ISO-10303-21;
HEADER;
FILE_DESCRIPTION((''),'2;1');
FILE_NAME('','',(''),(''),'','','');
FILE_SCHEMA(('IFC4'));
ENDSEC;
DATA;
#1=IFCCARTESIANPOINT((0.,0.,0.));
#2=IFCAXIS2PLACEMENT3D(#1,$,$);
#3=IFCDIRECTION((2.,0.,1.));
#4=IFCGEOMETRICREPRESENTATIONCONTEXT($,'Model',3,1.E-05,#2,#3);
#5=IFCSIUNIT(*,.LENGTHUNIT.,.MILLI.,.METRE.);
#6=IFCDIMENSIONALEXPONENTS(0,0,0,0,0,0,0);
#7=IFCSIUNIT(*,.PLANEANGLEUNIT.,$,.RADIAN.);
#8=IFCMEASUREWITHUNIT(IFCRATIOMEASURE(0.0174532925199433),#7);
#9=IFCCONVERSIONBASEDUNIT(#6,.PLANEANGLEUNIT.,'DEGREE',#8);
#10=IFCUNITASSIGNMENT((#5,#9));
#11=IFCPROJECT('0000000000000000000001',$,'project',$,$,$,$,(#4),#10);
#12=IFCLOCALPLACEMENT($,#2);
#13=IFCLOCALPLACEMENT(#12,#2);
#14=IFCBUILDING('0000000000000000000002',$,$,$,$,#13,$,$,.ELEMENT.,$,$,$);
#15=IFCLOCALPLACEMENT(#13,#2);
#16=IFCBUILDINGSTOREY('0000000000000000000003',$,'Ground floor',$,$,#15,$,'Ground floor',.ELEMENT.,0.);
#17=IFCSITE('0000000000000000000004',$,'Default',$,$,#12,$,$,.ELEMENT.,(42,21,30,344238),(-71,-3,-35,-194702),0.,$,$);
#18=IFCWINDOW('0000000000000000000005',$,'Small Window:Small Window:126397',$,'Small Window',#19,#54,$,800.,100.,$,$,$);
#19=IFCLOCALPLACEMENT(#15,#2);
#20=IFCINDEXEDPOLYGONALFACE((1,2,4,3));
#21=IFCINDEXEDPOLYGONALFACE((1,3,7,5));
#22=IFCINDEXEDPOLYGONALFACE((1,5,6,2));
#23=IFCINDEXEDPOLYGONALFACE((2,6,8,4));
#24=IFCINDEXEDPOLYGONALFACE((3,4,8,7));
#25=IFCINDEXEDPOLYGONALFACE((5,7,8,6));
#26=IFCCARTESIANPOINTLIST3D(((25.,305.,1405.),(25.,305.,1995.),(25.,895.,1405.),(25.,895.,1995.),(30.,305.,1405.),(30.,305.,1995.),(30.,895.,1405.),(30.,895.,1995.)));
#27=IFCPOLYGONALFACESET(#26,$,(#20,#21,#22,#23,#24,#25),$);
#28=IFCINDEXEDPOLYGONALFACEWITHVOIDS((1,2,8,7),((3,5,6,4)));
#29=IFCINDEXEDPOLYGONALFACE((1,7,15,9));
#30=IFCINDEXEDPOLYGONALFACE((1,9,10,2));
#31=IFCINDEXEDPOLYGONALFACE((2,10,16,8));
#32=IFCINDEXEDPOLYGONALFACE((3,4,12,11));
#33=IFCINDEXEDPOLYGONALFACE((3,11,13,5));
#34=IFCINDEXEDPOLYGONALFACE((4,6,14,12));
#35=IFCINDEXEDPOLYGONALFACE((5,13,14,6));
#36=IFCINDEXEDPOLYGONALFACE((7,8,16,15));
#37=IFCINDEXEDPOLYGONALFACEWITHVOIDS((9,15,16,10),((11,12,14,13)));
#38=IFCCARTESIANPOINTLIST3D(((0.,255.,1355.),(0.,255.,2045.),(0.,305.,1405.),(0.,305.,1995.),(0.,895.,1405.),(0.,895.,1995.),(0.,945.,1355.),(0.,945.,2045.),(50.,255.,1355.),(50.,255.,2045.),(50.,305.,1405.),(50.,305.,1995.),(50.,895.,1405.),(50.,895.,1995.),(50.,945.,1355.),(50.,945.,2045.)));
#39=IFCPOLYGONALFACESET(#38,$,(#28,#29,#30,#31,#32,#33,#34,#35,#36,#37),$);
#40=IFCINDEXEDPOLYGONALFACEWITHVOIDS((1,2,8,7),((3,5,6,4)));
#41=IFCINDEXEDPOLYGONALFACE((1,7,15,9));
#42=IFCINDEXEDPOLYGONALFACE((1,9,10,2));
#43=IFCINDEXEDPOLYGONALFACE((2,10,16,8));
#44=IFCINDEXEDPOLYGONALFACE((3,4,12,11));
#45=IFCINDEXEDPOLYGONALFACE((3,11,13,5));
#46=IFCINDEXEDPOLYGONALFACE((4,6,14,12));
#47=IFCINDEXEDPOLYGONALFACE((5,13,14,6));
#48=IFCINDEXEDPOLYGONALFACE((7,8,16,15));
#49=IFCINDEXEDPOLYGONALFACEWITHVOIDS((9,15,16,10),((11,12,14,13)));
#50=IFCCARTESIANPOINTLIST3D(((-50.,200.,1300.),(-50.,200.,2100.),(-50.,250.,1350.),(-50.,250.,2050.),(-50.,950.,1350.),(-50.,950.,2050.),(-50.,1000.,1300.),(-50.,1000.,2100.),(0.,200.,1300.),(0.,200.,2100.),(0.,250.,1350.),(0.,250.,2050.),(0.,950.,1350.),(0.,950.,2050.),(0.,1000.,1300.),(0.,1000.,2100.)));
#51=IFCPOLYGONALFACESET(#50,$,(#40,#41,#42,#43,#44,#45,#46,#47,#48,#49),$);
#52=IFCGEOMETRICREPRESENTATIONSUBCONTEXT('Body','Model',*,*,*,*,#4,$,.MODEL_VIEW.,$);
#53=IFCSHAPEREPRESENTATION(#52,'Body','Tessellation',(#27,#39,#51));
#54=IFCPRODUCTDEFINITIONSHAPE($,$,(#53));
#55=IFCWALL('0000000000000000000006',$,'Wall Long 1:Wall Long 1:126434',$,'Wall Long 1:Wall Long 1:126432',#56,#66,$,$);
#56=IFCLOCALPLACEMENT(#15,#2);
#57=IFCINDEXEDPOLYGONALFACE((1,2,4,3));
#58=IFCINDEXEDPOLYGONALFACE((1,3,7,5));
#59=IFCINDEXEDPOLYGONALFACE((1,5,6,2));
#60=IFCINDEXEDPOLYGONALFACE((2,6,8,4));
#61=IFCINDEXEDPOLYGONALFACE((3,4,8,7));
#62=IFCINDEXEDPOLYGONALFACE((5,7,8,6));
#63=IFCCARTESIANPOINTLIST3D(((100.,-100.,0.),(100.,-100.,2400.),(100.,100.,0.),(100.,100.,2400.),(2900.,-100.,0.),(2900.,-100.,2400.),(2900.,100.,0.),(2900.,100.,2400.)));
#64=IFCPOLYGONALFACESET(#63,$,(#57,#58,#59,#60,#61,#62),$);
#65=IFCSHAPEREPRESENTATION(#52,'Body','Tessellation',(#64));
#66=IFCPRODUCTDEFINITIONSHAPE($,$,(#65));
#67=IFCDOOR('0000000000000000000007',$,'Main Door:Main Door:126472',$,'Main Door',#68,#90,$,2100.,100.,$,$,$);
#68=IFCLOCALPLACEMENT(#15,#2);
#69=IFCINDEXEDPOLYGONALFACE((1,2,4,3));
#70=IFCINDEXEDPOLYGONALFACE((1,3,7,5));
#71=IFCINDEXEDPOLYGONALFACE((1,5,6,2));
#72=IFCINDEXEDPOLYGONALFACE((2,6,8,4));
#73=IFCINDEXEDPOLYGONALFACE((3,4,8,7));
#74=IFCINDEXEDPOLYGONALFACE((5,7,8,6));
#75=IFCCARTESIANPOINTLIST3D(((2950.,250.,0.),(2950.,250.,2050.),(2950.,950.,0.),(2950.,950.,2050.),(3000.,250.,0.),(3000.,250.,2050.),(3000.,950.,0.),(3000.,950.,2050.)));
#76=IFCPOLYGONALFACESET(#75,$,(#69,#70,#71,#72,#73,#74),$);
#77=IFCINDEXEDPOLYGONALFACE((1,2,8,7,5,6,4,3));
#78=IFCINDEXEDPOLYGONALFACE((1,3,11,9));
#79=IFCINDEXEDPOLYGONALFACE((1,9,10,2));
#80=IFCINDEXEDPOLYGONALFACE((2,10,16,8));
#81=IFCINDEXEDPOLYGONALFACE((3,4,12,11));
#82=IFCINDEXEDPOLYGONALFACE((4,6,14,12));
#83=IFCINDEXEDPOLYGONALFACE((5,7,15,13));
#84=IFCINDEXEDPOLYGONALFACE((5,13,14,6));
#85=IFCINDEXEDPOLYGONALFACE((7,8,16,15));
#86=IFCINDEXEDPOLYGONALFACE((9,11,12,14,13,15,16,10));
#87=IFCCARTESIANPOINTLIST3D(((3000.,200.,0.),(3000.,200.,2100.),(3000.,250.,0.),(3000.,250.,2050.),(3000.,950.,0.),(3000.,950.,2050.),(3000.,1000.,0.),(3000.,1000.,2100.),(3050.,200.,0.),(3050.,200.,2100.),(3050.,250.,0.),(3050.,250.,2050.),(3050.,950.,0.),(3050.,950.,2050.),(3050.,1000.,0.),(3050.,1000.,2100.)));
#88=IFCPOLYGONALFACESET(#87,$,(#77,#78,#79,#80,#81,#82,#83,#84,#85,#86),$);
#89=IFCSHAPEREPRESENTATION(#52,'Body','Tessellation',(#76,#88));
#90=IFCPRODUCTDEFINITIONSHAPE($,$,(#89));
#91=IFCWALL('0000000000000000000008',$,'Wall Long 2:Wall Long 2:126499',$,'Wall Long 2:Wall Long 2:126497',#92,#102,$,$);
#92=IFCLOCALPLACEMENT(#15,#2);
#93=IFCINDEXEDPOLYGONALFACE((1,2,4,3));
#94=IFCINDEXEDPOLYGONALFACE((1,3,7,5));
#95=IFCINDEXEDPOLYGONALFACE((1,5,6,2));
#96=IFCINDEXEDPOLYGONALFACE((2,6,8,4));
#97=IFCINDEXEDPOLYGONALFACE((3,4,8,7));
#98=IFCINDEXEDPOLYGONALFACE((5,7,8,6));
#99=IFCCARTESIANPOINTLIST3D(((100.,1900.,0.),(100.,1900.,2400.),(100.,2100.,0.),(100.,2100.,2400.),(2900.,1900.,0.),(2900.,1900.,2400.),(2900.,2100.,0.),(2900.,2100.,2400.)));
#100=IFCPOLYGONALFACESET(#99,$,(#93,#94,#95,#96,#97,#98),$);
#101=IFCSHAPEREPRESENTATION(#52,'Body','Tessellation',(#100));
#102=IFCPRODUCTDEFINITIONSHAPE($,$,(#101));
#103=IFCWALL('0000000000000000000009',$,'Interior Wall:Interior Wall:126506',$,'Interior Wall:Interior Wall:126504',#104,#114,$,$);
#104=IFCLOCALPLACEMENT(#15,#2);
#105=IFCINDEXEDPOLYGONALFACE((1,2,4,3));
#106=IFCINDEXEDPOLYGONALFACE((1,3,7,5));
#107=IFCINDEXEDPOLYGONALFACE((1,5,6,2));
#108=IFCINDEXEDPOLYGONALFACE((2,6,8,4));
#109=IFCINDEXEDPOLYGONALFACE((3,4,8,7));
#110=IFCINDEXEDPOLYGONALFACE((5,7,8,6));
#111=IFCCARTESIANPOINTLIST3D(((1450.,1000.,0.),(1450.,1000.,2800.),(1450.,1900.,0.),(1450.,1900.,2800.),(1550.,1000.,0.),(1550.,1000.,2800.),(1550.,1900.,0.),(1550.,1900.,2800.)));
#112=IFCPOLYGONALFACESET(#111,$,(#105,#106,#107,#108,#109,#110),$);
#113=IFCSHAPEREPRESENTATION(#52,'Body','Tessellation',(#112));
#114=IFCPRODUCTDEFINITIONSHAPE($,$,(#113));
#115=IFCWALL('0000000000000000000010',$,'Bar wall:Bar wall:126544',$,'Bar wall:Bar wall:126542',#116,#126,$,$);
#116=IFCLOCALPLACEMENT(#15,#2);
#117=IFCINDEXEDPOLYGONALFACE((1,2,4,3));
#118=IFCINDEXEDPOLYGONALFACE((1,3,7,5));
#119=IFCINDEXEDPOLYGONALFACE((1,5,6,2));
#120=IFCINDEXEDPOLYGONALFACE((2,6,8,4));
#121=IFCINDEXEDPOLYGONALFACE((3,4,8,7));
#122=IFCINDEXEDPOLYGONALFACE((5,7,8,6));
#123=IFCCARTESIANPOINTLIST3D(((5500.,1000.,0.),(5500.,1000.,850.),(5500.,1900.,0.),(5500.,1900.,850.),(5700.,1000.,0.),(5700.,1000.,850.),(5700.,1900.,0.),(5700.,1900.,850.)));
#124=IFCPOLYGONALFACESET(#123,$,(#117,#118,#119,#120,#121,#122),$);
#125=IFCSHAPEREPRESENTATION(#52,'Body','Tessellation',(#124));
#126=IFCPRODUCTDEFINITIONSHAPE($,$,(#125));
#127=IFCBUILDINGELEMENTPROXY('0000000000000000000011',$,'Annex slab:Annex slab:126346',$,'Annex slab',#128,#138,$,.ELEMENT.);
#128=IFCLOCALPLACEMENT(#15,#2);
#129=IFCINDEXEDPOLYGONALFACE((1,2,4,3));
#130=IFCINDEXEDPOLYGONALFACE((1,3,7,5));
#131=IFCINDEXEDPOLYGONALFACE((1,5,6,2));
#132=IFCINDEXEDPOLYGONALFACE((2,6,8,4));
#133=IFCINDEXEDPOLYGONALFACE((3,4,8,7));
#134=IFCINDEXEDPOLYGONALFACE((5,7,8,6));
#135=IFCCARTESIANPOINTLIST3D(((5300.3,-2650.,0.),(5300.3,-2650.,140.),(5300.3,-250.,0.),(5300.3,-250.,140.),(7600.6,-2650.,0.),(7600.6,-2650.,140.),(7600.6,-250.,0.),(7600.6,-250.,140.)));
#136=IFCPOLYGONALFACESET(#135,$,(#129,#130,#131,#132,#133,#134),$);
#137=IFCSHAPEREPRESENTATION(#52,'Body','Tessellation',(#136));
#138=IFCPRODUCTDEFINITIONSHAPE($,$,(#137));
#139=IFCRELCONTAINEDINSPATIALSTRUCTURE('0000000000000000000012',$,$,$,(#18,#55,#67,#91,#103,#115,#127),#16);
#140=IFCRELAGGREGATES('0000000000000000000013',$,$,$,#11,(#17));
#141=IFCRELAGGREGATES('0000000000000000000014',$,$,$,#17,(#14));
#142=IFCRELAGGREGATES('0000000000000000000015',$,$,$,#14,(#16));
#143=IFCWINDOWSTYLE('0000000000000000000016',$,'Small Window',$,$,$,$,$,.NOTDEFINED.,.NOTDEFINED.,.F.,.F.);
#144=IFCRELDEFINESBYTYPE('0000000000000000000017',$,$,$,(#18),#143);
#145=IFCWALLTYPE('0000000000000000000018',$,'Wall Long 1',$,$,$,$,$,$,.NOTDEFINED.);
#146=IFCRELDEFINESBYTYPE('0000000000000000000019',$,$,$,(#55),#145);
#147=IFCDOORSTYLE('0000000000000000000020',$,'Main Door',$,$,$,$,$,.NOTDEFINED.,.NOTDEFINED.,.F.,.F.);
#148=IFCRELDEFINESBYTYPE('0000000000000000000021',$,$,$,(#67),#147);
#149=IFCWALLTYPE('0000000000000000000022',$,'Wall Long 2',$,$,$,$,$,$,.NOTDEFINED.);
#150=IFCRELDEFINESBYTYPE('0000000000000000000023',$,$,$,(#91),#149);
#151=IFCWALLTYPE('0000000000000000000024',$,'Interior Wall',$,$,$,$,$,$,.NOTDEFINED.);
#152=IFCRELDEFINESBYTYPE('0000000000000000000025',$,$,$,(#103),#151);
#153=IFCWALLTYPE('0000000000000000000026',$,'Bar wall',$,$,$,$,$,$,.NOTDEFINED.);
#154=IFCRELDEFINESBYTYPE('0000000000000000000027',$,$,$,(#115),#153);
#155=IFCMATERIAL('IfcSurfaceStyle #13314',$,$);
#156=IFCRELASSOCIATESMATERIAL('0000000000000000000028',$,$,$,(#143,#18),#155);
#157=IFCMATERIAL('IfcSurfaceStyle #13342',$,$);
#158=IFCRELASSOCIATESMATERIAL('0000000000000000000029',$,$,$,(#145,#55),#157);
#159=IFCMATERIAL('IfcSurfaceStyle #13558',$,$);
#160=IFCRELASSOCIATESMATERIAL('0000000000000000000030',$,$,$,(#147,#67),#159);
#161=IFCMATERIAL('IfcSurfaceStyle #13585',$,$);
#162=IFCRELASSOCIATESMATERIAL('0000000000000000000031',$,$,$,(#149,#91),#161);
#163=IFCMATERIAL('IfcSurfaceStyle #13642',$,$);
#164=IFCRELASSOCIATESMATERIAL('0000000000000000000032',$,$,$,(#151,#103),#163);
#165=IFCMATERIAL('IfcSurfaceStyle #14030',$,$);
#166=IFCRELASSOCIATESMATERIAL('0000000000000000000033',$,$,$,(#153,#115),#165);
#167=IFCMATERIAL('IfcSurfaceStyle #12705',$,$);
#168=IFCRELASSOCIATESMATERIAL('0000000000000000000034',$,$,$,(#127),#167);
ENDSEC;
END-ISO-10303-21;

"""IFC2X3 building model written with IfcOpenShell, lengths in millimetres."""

from ifc_helpers import new_model, entity, si_unit, converted_unit, direction, frame, frame_2d, origin, origin_2d_with_axis, place, context, subcontext, project, spatial, polyline, rectangle, outline, extrude, source, transform, mapped, material, type_object, type_shapes, element, save


model = new_model("IFC2X3")

# Units and contexts
model_context = context("Model", 3, precision=1e-05, world=origin(), true_north=direction((2.0, 0.0, 1.0)))
body_context = subcontext(model_context, "Body", "Model", "MODEL_VIEW")
ifc_project = project(units=[si_unit("LENGTHUNIT", "METRE", prefix="MILLI"), converted_unit("PLANEANGLEUNIT", "DEGREE", entity("IfcRatioMeasure", 0.0174532925199433), si_unit("PLANEANGLEUNIT", "RADIAN"), dimensions=[0, 0, 0, 0, 0, 0, 0])], contexts=[model_context])

# Site, building, storey
site_placement = place(None, origin())
site = spatial("IfcSite", under=ifc_project, at=site_placement, Name="Default", CompositionType="ELEMENT", RefLatitude=(42, 21, 30, 344238), RefLongitude=(-71, -3, -35, -194702), RefElevation=0.0)
building_placement = place(site_placement, origin())
building = spatial("IfcBuilding", under=site, at=building_placement, CompositionType="ELEMENT")
storey_placement = place(building_placement, origin())
storey = spatial("IfcBuildingStorey", under=building, at=storey_placement, Name="Ground floor", LongName="Ground floor", CompositionType="ELEMENT", Elevation=0.0)

# Window
ifc_material_1 = material(Name="IfcSurfaceStyle #13314")
window_style = type_object("IfcWindowStyle", Name="Small Window", ConstructionType="NOTDEFINED", OperationType="NOTDEFINED", ParameterTakesPrecedence=False, Sizeable=False, material=ifc_material_1)
shared_shape_1 = source(origin(), body_context, "Body", "SweptSolid", [
    extrude(rectangle(XDim=5.0, YDim=590.0, at=frame_2d((0.0, 0.0), x_axis=(1.0, 0.0))), frame((27.5, 600.0, 1405.0), z_axis=(0.0, 0.0, 1.0), x_axis=(-1.0, 0.0, 0.0)), (0.0, 0.0, 1.0), 590.0),
    extrude(outline(polyline([(-345.0, -345.0), (345.0, -345.0), (345.0, 345.0), (-345.0, 345.0), (-345.0, -345.0)]), holes=[polyline([(-295.0, 295.0), (295.0, 295.0), (295.0, -295.0), (-295.0, -295.0), (-295.0, 295.0)])]), frame((0.0, 600.0, 1700.0), z_axis=(1.0, 0.0, 0.0), x_axis=(0.0, 1.0, 0.0)), (0.0, 0.0, 1.0), 50.0),
    extrude(outline(polyline([(-400.0, -400.0), (400.0, -400.0), (400.0, 400.0), (-400.0, 400.0), (-400.0, -400.0)]), holes=[polyline([(-350.0, 350.0), (350.0, 350.0), (350.0, -350.0), (-350.0, -350.0), (-350.0, 350.0)])]), frame((-50.0, 600.0, 1700.0), z_axis=(1.0, 0.0, 0.0), x_axis=(0.0, 1.0, 0.0)), (0.0, 0.0, 1.0), 50.0),
])
type_shapes(window_style, [shared_shape_1])
window_placement = place(storey_placement, origin())
element("IfcWindow", 1, at=window_placement, inside=storey, type_object=window_style, material=ifc_material_1, Name="Small Window:Small Window:126397", ObjectType="Small Window", OverallHeight=800.0, OverallWidth=100.0, context=body_context, shape_type="MappedRepresentation", body=[
    mapped(shared_shape_1, transform((0.0, 0.0, 0.0), scale=1.0)),
])

# Wall
ifc_material_2 = material(Name="IfcSurfaceStyle #13342")
wall_type_1 = type_object("IfcWallType", Name="Wall Long 1", PredefinedType="NOTDEFINED", material=ifc_material_2)
wall_1_placement = place(storey_placement, frame((100.0, -100.0, 0.0)))
element("IfcWall", 2, at=wall_1_placement, inside=storey, type_object=wall_type_1, material=ifc_material_2, Name="Wall Long 1:Wall Long 1:126434", ObjectType="Wall Long 1:Wall Long 1:126432", context=body_context, shape_type="SweptSolid", body=[
    extrude(rectangle(XDim=200.0, YDim=2800.0, at=origin_2d_with_axis()), frame((1400.0, 100.0, 0.0), z_axis=(0.0, 0.0, 1.0), x_axis=(0.0, 1.0, 0.0)), (0.0, 0.0, 1.0), 2400.0),
])

# Door
ifc_material_3 = material(Name="IfcSurfaceStyle #13558")
door_style_1 = type_object("IfcDoorStyle", Name="Main Door", ConstructionType="NOTDEFINED", OperationType="NOTDEFINED", ParameterTakesPrecedence=False, Sizeable=False, material=ifc_material_3)
shared_shape_2 = source(origin(), body_context, "Body", "SweptSolid", [
    extrude(rectangle(XDim=50.0, YDim=700.0, at=frame_2d((0.0, 0.0), x_axis=(1.0, 0.0))), frame((2975.0, 600.0, 0.0)), (0.0, 0.0, 1.0), 2050.0),
    extrude(outline(polyline([(-400.0, -1062.5), (400.0, -1062.5), (400.0, 1037.5), (350.0, 1037.5), (350.0, -1012.5), (-350.0, -1012.5), (-350.0, 1037.5), (-400.0, 1037.5), (-400.0, -1062.5)])), frame((3000.0, 600.0, 1037.5), z_axis=(1.0, 0.0, 0.0), x_axis=(0.0, -1.0, 0.0)), (0.0, 0.0, 1.0), 50.0),
])
type_shapes(door_style_1, [shared_shape_2])
door_1_placement = place(storey_placement, origin())
element("IfcDoor", 3, at=door_1_placement, inside=storey, type_object=door_style_1, material=ifc_material_3, Name="Main Door:Main Door:126472", ObjectType="Main Door", OverallHeight=2100.0, OverallWidth=100.0, context=body_context, shape_type="MappedRepresentation", body=[
    mapped(shared_shape_2, transform((0.0, 0.0, 0.0), scale=1.0)),
])

# Walls
ifc_material_4 = material(Name="IfcSurfaceStyle #13585")
wall_type_2 = type_object("IfcWallType", Name="Wall Long 2", PredefinedType="NOTDEFINED", material=ifc_material_4)
wall_2_placement = place(storey_placement, frame((100.0, 1900.0, 0.0)))
element("IfcWall", 4, at=wall_2_placement, inside=storey, type_object=wall_type_2, material=ifc_material_4, Name="Wall Long 2:Wall Long 2:126499", ObjectType="Wall Long 2:Wall Long 2:126497", context=body_context, shape_type="SweptSolid", body=[
    extrude(rectangle(XDim=200.0, YDim=2800.0, at=origin_2d_with_axis()), frame((1400.0, 100.0, 0.0), z_axis=(0.0, 0.0, 1.0), x_axis=(0.0, -1.0, 0.0)), (0.0, 0.0, 1.0), 2400.0),
])
ifc_material_5 = material(Name="IfcSurfaceStyle #13642")
wall_type_3 = type_object("IfcWallType", Name="Interior Wall", PredefinedType="NOTDEFINED", material=ifc_material_5)
wall_3_placement = place(storey_placement, frame((1450.0, 1000.0, 0.0), z_axis=(0.0, 0.0, 1.0), x_axis=(0.0, 1.0, 0.0)))
element("IfcWall", 5, at=wall_3_placement, inside=storey, type_object=wall_type_3, material=ifc_material_5, Name="Interior Wall:Interior Wall:126506", ObjectType="Interior Wall:Interior Wall:126504", context=body_context, shape_type="SweptSolid", body=[
    extrude(rectangle(XDim=900.0, YDim=100.0, at=origin_2d_with_axis()), frame((450.0, -50.0, 0.0), z_axis=(0.0, 0.0, 1.0), x_axis=(-1.0, 0.0, 0.0)), (0.0, 0.0, 1.0), 2800.0),
])
ifc_material_6 = material(Name="IfcSurfaceStyle #14030")
wall_type_4 = type_object("IfcWallType", Name="Bar wall", PredefinedType="NOTDEFINED", material=ifc_material_6)
wall_4_placement = place(storey_placement, frame((5500.0, 1000.0, 0.0), z_axis=(0.0, 0.0, 1.0), x_axis=(0.0, 1.0, 0.0)))
element("IfcWall", 6, at=wall_4_placement, inside=storey, type_object=wall_type_4, material=ifc_material_6, Name="Bar wall:Bar wall:126544", ObjectType="Bar wall:Bar wall:126542", context=body_context, shape_type="SweptSolid", body=[
    extrude(rectangle(XDim=200.0, YDim=900.0, at=origin_2d_with_axis()), frame((450.0, -100.0, 0.0), z_axis=(0.0, 0.0, 1.0), x_axis=(0.0, -1.0, 0.0)), (0.0, 0.0, 1.0), 850.0),
])

# Building element proxy
ifc_material_7 = material(Name="IfcSurfaceStyle #12705")
shared_shape_3 = source(origin(), body_context, "Body", "SweptSolid", [
    extrude(rectangle(XDim=2300.3, YDim=2400.0, at=frame_2d((0.0, 0.0), x_axis=(1.0, 0.0))), frame((6450.4, -1450.0, 0.0)), (0.0, 0.0, 1.0), 140.0),
])
proxy_1_placement = place(storey_placement, origin())
element("IfcBuildingElementProxy", 7, at=proxy_1_placement, inside=storey, material=ifc_material_7, Name="Annex slab:Annex slab:126346", ObjectType="Annex slab", CompositionType="ELEMENT", context=body_context, shape_type="MappedRepresentation", body=[
    mapped(shared_shape_3, transform((0.0, 0.0, 0.0), scale=1.0)),
])

save(model, "model.ifc")
